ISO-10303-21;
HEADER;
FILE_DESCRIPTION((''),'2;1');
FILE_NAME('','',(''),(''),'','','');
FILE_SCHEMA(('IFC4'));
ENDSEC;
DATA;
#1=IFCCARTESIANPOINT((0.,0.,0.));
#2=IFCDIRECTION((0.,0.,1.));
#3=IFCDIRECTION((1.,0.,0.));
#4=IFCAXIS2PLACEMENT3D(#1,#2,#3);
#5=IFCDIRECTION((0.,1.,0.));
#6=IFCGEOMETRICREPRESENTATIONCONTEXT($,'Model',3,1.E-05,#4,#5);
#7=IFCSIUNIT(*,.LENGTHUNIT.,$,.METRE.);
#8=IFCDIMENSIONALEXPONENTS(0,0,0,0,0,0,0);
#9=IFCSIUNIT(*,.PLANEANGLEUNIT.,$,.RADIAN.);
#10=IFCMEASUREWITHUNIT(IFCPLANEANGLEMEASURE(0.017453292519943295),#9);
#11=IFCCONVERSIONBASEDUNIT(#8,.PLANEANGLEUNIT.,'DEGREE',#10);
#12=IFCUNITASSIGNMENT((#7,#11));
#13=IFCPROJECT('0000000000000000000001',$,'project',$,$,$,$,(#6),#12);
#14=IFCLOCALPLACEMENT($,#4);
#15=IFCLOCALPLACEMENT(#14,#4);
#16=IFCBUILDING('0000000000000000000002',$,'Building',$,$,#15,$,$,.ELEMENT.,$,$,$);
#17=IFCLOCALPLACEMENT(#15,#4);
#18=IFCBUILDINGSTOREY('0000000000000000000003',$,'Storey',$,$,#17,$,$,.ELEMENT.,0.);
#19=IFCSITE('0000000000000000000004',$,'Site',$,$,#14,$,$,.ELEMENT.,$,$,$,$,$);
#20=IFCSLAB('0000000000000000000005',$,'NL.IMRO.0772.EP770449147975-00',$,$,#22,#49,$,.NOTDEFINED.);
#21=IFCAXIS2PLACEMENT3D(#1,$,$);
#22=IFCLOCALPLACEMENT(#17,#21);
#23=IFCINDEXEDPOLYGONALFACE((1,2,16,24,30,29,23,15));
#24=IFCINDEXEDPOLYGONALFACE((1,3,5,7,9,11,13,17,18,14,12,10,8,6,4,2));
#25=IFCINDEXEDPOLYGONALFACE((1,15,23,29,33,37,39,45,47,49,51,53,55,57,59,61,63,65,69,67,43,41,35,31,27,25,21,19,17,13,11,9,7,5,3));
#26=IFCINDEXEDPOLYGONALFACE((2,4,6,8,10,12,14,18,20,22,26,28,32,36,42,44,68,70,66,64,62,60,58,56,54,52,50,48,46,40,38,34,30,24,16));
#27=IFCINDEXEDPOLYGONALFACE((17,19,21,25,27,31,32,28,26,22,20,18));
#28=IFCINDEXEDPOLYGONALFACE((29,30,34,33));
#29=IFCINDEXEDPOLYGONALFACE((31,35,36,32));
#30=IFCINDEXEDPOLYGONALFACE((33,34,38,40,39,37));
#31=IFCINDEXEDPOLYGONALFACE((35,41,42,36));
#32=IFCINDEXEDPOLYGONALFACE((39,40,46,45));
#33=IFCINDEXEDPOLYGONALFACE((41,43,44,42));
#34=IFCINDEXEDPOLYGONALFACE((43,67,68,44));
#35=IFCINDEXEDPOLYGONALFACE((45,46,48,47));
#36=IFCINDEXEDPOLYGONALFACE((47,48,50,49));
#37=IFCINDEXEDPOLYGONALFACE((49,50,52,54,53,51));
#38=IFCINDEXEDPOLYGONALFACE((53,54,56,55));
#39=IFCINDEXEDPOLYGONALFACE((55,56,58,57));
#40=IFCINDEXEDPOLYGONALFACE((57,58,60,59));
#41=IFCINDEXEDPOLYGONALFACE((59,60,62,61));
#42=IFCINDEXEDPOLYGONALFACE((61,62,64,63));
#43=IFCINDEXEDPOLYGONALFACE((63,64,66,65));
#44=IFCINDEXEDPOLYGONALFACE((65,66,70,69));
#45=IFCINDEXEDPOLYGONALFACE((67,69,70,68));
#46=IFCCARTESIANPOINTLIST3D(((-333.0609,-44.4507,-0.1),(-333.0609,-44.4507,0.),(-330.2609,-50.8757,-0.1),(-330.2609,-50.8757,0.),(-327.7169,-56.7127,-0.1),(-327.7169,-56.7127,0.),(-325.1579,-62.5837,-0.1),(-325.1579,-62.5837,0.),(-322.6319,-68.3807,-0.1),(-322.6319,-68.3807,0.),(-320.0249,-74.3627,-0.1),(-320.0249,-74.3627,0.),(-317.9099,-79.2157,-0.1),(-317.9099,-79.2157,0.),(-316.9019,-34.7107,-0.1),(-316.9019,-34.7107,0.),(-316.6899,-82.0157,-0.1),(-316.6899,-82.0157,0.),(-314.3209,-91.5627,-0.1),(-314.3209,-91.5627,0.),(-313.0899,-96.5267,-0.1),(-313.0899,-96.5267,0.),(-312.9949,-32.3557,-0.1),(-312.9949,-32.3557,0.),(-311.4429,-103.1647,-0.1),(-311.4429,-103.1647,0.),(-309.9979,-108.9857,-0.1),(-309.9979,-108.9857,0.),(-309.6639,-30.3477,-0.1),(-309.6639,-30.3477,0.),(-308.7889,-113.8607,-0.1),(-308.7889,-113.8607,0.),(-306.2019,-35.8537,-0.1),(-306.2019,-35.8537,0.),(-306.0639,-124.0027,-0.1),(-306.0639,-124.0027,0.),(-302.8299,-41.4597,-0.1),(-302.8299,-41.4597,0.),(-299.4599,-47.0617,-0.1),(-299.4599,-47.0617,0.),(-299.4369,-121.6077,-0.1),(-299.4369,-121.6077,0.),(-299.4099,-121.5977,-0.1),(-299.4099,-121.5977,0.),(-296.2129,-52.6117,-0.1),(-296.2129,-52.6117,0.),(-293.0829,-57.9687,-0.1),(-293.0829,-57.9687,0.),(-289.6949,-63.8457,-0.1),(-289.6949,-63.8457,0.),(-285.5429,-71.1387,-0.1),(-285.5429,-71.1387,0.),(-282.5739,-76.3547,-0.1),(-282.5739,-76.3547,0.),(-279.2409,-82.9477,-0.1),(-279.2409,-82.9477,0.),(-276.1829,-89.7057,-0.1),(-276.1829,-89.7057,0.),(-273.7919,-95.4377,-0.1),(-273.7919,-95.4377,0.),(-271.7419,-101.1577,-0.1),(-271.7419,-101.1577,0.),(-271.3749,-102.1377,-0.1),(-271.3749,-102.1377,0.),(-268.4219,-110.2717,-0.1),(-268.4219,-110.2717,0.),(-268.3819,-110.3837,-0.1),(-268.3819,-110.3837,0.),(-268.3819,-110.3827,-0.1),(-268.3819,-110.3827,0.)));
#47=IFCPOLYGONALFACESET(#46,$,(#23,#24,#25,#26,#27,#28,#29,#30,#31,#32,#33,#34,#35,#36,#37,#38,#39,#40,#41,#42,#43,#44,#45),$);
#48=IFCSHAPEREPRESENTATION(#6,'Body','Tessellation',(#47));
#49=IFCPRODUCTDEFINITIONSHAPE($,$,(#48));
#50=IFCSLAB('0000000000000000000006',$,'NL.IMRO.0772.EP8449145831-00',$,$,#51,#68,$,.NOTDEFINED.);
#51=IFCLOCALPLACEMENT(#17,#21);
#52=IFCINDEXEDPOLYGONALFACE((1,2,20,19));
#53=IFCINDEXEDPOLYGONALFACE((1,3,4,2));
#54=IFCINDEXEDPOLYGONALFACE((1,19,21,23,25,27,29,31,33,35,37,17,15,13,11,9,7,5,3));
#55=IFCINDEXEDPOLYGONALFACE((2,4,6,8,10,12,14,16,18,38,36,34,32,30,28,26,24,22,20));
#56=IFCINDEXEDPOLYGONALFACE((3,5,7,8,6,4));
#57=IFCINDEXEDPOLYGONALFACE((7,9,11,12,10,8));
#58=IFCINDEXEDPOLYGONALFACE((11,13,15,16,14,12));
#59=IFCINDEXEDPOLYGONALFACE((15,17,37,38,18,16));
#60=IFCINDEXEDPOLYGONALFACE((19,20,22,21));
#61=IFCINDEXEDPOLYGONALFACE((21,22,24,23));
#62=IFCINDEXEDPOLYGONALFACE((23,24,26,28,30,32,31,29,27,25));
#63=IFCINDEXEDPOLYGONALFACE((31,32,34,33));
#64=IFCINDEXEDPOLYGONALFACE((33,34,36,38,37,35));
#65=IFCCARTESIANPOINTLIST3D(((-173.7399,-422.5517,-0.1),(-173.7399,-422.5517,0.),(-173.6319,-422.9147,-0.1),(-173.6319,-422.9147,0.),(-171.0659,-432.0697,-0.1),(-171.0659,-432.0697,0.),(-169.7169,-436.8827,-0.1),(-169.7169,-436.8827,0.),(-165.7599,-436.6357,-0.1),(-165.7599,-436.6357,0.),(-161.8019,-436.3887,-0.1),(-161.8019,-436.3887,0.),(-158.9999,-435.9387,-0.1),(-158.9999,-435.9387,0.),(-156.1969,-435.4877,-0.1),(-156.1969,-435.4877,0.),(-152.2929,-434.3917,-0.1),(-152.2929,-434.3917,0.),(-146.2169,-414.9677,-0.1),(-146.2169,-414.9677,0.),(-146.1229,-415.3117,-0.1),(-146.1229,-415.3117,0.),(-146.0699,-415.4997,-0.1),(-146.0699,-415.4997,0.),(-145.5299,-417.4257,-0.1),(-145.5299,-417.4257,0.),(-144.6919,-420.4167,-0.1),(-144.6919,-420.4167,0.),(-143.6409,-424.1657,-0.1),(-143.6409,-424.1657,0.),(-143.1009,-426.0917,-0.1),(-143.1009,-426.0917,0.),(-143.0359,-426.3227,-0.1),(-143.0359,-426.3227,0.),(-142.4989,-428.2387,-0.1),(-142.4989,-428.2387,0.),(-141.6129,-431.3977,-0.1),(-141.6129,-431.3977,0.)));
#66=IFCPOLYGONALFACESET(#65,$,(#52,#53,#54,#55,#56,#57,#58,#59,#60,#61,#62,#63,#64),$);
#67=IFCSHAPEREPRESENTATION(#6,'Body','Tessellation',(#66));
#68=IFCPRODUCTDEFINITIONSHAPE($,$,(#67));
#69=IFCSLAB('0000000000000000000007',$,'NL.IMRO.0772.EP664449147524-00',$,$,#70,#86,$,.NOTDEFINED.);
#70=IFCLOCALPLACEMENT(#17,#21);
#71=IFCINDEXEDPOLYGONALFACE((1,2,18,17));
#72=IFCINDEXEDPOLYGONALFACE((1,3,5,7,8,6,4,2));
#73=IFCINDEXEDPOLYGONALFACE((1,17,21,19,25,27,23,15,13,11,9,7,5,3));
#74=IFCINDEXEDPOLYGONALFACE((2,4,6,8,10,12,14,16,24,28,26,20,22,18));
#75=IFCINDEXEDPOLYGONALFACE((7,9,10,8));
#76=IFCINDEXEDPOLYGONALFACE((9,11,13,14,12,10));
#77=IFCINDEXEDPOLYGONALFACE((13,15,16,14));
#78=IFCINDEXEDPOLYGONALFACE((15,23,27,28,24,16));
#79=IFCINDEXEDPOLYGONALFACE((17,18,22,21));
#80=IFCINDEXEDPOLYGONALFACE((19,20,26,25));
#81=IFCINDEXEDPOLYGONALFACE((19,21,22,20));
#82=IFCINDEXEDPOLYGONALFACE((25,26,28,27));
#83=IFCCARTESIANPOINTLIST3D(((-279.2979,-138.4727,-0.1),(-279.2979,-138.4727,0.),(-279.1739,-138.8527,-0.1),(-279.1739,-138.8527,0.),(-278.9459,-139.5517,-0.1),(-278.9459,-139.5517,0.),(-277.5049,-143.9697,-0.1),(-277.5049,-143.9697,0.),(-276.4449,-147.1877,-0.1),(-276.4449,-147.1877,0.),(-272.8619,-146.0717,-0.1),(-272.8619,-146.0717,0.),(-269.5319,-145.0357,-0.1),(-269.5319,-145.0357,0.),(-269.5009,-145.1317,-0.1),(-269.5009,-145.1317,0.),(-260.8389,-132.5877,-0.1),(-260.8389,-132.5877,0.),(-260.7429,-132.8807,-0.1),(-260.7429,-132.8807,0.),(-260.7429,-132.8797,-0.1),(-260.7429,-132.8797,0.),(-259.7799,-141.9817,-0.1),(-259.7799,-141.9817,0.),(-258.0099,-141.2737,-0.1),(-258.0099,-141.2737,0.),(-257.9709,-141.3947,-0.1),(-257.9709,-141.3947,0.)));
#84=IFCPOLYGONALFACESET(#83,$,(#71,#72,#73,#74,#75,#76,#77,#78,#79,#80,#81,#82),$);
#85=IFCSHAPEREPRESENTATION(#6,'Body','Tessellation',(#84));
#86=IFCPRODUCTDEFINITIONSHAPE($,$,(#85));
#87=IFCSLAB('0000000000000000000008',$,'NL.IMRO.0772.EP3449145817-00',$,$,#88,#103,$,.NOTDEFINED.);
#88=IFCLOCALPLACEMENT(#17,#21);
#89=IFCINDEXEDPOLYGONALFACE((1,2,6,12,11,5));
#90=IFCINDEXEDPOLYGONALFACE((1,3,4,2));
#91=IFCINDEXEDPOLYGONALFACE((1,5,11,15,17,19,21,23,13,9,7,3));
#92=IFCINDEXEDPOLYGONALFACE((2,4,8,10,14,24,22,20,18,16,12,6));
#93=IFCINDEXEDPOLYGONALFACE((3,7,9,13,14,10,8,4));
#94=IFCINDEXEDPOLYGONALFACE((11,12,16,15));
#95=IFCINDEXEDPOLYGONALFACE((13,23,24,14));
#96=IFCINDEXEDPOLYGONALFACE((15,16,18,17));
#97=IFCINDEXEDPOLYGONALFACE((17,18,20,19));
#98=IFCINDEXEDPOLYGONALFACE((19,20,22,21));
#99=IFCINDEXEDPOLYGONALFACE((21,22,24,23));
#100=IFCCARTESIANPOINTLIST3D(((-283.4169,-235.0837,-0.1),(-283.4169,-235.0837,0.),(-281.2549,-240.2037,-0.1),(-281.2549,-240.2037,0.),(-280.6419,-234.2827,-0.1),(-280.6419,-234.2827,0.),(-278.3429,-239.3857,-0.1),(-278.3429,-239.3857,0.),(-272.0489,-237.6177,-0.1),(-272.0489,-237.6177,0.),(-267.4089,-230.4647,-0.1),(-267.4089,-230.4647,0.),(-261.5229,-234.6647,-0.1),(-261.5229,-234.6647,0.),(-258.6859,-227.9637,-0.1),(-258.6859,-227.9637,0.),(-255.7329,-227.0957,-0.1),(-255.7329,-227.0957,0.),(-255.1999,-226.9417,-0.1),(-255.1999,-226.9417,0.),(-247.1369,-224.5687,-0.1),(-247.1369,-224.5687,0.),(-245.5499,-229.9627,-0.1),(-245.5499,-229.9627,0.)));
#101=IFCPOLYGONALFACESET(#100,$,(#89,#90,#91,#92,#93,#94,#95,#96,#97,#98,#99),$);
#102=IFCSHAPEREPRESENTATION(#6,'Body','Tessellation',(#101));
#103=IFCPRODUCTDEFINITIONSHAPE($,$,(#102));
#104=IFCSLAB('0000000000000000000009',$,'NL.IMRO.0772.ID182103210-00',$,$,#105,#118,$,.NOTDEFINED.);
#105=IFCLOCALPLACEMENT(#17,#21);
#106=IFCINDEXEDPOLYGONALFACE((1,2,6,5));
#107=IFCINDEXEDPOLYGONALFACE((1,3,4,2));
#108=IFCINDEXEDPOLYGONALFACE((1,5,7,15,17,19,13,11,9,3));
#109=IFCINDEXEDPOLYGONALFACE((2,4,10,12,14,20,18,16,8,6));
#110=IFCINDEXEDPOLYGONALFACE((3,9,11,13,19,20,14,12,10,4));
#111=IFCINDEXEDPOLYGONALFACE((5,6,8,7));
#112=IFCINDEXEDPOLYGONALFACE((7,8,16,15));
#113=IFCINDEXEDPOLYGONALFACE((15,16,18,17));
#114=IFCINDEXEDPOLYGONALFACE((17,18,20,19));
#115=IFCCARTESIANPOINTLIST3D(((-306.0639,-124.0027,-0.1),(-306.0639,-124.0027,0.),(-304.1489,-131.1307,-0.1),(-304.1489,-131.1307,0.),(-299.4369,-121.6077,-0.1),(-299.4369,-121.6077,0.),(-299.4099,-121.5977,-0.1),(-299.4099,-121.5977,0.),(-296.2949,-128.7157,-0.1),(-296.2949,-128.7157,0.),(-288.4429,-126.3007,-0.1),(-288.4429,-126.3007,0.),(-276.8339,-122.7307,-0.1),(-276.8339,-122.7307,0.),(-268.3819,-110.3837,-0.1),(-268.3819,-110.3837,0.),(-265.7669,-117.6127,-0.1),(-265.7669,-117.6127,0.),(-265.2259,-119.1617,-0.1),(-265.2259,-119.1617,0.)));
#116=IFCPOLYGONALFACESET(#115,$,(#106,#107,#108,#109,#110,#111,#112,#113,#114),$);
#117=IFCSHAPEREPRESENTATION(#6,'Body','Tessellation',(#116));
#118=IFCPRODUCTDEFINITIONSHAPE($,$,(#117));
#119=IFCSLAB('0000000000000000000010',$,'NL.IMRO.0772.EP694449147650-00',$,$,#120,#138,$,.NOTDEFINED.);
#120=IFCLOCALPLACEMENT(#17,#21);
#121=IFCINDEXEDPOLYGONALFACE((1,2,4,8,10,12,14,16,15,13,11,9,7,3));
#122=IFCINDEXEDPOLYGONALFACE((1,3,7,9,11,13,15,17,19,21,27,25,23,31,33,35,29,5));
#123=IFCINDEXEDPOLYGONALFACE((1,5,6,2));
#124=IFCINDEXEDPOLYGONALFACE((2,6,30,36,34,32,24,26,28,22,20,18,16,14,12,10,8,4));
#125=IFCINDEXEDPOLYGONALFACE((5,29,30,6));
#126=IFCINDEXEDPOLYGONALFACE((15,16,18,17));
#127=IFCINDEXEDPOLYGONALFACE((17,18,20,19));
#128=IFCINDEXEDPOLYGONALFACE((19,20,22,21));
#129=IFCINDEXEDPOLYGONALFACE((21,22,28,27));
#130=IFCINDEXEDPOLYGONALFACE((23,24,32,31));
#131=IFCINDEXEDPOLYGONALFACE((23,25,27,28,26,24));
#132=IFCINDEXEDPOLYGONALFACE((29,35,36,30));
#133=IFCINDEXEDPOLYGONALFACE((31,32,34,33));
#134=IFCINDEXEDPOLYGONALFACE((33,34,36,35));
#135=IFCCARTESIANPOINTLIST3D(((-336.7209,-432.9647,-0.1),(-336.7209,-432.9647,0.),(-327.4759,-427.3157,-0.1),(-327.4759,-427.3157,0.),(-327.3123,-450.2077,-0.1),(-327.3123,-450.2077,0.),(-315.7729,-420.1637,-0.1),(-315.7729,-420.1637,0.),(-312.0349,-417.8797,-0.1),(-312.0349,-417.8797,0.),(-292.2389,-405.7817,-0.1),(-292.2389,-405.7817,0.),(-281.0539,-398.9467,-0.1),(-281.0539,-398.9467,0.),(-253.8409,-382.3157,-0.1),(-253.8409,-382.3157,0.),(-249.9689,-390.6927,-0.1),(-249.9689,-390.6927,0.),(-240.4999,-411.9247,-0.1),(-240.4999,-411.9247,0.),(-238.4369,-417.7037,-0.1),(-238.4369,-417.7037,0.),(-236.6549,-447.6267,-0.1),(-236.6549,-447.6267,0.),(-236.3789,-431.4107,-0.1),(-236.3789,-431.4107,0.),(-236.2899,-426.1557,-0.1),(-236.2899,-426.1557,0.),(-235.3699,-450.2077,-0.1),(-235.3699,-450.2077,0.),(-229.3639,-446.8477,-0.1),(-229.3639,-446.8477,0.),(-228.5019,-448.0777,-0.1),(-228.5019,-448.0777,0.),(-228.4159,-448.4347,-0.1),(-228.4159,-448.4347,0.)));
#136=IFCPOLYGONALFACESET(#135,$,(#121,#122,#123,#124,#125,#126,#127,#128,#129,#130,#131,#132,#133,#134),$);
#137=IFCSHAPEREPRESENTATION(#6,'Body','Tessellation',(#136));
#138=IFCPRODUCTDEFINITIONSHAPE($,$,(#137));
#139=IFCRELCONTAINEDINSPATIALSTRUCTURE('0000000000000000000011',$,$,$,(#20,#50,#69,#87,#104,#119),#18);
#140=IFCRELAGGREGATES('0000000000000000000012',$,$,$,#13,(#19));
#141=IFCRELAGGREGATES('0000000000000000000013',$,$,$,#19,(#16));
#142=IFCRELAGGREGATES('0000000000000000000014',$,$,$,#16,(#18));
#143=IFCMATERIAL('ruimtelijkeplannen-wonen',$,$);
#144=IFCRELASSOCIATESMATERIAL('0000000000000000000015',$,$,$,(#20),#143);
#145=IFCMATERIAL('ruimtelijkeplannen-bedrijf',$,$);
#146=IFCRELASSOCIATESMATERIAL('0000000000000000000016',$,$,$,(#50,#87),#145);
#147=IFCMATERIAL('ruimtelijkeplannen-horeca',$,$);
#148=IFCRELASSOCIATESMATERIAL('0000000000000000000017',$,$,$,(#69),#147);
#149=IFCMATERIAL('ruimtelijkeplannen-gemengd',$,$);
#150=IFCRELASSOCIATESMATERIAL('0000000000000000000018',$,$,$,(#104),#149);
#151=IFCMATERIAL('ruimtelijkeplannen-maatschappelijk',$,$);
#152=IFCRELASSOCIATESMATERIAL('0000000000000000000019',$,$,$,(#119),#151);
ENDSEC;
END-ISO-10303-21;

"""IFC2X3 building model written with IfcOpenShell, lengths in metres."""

from ifc_helpers import new_model, entity, si_unit, converted_unit, direction, frame, origin_with_axes, place, context, project, spatial, polyline, outline, extrude, material, element, save


model = new_model("IFC2X3")

# Units and contexts
model_context = context("Model", 3, precision=1e-05, world=origin_with_axes(), true_north=direction((0.0, 1.0, 0.0)))
ifc_project = project(units=[si_unit("LENGTHUNIT", "METRE"), converted_unit("PLANEANGLEUNIT", "DEGREE", entity("IfcPlaneAngleMeasure", 0.017453292519943295), si_unit("PLANEANGLEUNIT", "RADIAN"), dimensions=[0, 0, 0, 0, 0, 0, 0])], contexts=[model_context])

# Site, building, storey
site_placement = place(None, origin_with_axes())
site = spatial("IfcSite", under=ifc_project, at=site_placement, Name="Site", CompositionType="ELEMENT")
building_placement = place(site_placement, origin_with_axes())
building = spatial("IfcBuilding", under=site, at=building_placement, Name="Building", CompositionType="ELEMENT")
storey_placement = place(building_placement, origin_with_axes())
storey = spatial("IfcBuildingStorey", under=building, at=storey_placement, Name="Storey", CompositionType="ELEMENT", Elevation=0.0)

# Slabs
ifc_material_1 = material(Name="ruimtelijkeplannen-wonen")
slab_1_placement = place(storey_placement, frame((0.0, 0.0, -0.1), z_axis=(0.0, 0.0, 1.0), x_axis=(1.0, 0.0, 0.0)))
element("IfcSlab", 1, at=slab_1_placement, inside=storey, material=ifc_material_1, Name="NL.IMRO.0772.EP770449147975-00", PredefinedType="NOTDEFINED", context=model_context, shape_type="SweptSolid", body=[
    extrude(outline(polyline([(-268.3819, -110.3827), (-268.3819, -110.3837), (-299.4099, -121.5977), (-299.4369, -121.6077), (-306.0639, -124.0027), (-308.7889, -113.8607), (-309.9979, -108.9857), (-311.4429, -103.1647), (-313.0899, -96.5267), (-314.3209, -91.5627), (-316.6899, -82.0157), (-317.9099, -79.2157), (-320.0249, -74.3627), (-322.6319, -68.3807), (-325.1579, -62.5837), (-327.7169, -56.7127), (-330.2609, -50.8757), (-333.0609, -44.4507), (-316.9019, -34.7107), (-312.9949, -32.3557), (-309.6639, -30.3477), (-306.2019, -35.8537), (-302.8299, -41.4597), (-299.4599, -47.0617), (-296.2129, -52.6117), (-293.0829, -57.9687), (-289.6949, -63.8457), (-285.5429, -71.1387), (-282.5739, -76.3547), (-279.2409, -82.9477), (-276.1829, -89.7057), (-273.7919, -95.4377), (-271.7419, -101.1577), (-271.3749, -102.1377), (-268.4219, -110.2717), (-268.3819, -110.3827)])), origin_with_axes(), (0.0, 0.0, 1.0), 0.1),
])
ifc_material_2 = material(Name="ruimtelijkeplannen-bedrijf")
slab_2_placement = place(storey_placement, frame((0.0, 0.0, -0.1), z_axis=(0.0, 0.0, 1.0), x_axis=(1.0, 0.0, 0.0)))
element("IfcSlab", 2, at=slab_2_placement, inside=storey, material=ifc_material_2, Name="NL.IMRO.0772.EP8449145831-00", PredefinedType="NOTDEFINED", context=model_context, shape_type="SweptSolid", body=[
    extrude(outline(polyline([(-146.0699, -415.4997), (-145.5299, -417.4257), (-144.6919, -420.4167), (-143.6409, -424.1657), (-143.1009, -426.0917), (-143.0359, -426.3227), (-142.4989, -428.2387), (-141.6129, -431.3977), (-152.2929, -434.3917), (-156.1969, -435.4877), (-158.9999, -435.9387), (-161.8019, -436.3887), (-165.7599, -436.6357), (-169.7169, -436.8827), (-171.0659, -432.0697), (-173.6319, -422.9147), (-173.7399, -422.5517), (-146.2169, -414.9677), (-146.1229, -415.3117), (-146.0699, -415.4997)])), origin_with_axes(), (0.0, 0.0, 1.0), 0.1),
])
ifc_material_3 = material(Name="ruimtelijkeplannen-horeca")
slab_3_placement = place(storey_placement, frame((0.0, 0.0, -0.1), z_axis=(0.0, 0.0, 1.0), x_axis=(1.0, 0.0, 0.0)))
element("IfcSlab", 3, at=slab_3_placement, inside=storey, material=ifc_material_3, Name="NL.IMRO.0772.EP664449147524-00", PredefinedType="NOTDEFINED", context=model_context, shape_type="SweptSolid", body=[
    extrude(outline(polyline([(-260.7429, -132.8807), (-258.0099, -141.2737), (-257.9709, -141.3947), (-259.7799, -141.9817), (-269.5009, -145.1317), (-269.5319, -145.0357), (-272.8619, -146.0717), (-276.4449, -147.1877), (-277.5049, -143.9697), (-278.9459, -139.5517), (-279.1739, -138.8527), (-279.2979, -138.4727), (-260.8389, -132.5877), (-260.7429, -132.8797), (-260.7429, -132.8807)])), origin_with_axes(), (0.0, 0.0, 1.0), 0.1),
])
slab_4_placement = place(storey_placement, frame((0.0, 0.0, -0.1), z_axis=(0.0, 0.0, 1.0), x_axis=(1.0, 0.0, 0.0)))
element("IfcSlab", 4, at=slab_4_placement, inside=storey, material=ifc_material_2, Name="NL.IMRO.0772.EP3449145817-00", PredefinedType="NOTDEFINED", context=model_context, shape_type="SweptSolid", body=[
    extrude(outline(polyline([(-245.5499, -229.9627), (-261.5229, -234.6647), (-272.0489, -237.6177), (-278.3429, -239.3857), (-281.2549, -240.2037), (-283.4169, -235.0837), (-280.6419, -234.2827), (-267.4089, -230.4647), (-258.6859, -227.9637), (-255.7329, -227.0957), (-255.1999, -226.9417), (-247.1369, -224.5687), (-245.5499, -229.9627)])), origin_with_axes(), (0.0, 0.0, 1.0), 0.1),
])
ifc_material_4 = material(Name="ruimtelijkeplannen-gemengd")
slab_5_placement = place(storey_placement, frame((0.0, 0.0, -0.1), z_axis=(0.0, 0.0, 1.0), x_axis=(1.0, 0.0, 0.0)))
element("IfcSlab", 5, at=slab_5_placement, inside=storey, material=ifc_material_4, Name="NL.IMRO.0772.ID182103210-00", PredefinedType="NOTDEFINED", context=model_context, shape_type="SweptSolid", body=[
    extrude(outline(polyline([(-265.7669, -117.6127), (-265.2259, -119.1617), (-276.8339, -122.7307), (-288.4429, -126.3007), (-296.2949, -128.7157), (-304.1489, -131.1307), (-306.0639, -124.0027), (-299.4369, -121.6077), (-299.4099, -121.5977), (-268.3819, -110.3837), (-265.7669, -117.6127)])), origin_with_axes(), (0.0, 0.0, 1.0), 0.1),
])
ifc_material_5 = material(Name="ruimtelijkeplannen-maatschappelijk")
slab_6_placement = place(storey_placement, frame((0.0, 0.0, -0.1), z_axis=(0.0, 0.0, 1.0), x_axis=(1.0, 0.0, 0.0)))
element("IfcSlab", 6, at=slab_6_placement, inside=storey, material=ifc_material_5, Name="NL.IMRO.0772.EP694449147650-00", PredefinedType="NOTDEFINED", context=model_context, shape_type="SweptSolid", body=[
    extrude(outline(polyline([(-336.7209, -432.9647), (-327.4759, -427.3157), (-315.7729, -420.1637), (-312.0349, -417.8797), (-292.2389, -405.7817), (-281.0539, -398.9467), (-253.8409, -382.3157), (-249.9689, -390.6927), (-240.4999, -411.9247), (-238.4369, -417.7037), (-236.2899, -426.1557), (-236.3789, -431.4107), (-236.6549, -447.6267), (-229.3639, -446.8477), (-228.5019, -448.0777), (-228.4159, -448.4347), (-235.3699, -450.2077), (-327.3123, -450.2077), (-336.7209, -432.9647)])), origin_with_axes(), (0.0, 0.0, 1.0), 0.1),
])

save(model, "model.ifc")
